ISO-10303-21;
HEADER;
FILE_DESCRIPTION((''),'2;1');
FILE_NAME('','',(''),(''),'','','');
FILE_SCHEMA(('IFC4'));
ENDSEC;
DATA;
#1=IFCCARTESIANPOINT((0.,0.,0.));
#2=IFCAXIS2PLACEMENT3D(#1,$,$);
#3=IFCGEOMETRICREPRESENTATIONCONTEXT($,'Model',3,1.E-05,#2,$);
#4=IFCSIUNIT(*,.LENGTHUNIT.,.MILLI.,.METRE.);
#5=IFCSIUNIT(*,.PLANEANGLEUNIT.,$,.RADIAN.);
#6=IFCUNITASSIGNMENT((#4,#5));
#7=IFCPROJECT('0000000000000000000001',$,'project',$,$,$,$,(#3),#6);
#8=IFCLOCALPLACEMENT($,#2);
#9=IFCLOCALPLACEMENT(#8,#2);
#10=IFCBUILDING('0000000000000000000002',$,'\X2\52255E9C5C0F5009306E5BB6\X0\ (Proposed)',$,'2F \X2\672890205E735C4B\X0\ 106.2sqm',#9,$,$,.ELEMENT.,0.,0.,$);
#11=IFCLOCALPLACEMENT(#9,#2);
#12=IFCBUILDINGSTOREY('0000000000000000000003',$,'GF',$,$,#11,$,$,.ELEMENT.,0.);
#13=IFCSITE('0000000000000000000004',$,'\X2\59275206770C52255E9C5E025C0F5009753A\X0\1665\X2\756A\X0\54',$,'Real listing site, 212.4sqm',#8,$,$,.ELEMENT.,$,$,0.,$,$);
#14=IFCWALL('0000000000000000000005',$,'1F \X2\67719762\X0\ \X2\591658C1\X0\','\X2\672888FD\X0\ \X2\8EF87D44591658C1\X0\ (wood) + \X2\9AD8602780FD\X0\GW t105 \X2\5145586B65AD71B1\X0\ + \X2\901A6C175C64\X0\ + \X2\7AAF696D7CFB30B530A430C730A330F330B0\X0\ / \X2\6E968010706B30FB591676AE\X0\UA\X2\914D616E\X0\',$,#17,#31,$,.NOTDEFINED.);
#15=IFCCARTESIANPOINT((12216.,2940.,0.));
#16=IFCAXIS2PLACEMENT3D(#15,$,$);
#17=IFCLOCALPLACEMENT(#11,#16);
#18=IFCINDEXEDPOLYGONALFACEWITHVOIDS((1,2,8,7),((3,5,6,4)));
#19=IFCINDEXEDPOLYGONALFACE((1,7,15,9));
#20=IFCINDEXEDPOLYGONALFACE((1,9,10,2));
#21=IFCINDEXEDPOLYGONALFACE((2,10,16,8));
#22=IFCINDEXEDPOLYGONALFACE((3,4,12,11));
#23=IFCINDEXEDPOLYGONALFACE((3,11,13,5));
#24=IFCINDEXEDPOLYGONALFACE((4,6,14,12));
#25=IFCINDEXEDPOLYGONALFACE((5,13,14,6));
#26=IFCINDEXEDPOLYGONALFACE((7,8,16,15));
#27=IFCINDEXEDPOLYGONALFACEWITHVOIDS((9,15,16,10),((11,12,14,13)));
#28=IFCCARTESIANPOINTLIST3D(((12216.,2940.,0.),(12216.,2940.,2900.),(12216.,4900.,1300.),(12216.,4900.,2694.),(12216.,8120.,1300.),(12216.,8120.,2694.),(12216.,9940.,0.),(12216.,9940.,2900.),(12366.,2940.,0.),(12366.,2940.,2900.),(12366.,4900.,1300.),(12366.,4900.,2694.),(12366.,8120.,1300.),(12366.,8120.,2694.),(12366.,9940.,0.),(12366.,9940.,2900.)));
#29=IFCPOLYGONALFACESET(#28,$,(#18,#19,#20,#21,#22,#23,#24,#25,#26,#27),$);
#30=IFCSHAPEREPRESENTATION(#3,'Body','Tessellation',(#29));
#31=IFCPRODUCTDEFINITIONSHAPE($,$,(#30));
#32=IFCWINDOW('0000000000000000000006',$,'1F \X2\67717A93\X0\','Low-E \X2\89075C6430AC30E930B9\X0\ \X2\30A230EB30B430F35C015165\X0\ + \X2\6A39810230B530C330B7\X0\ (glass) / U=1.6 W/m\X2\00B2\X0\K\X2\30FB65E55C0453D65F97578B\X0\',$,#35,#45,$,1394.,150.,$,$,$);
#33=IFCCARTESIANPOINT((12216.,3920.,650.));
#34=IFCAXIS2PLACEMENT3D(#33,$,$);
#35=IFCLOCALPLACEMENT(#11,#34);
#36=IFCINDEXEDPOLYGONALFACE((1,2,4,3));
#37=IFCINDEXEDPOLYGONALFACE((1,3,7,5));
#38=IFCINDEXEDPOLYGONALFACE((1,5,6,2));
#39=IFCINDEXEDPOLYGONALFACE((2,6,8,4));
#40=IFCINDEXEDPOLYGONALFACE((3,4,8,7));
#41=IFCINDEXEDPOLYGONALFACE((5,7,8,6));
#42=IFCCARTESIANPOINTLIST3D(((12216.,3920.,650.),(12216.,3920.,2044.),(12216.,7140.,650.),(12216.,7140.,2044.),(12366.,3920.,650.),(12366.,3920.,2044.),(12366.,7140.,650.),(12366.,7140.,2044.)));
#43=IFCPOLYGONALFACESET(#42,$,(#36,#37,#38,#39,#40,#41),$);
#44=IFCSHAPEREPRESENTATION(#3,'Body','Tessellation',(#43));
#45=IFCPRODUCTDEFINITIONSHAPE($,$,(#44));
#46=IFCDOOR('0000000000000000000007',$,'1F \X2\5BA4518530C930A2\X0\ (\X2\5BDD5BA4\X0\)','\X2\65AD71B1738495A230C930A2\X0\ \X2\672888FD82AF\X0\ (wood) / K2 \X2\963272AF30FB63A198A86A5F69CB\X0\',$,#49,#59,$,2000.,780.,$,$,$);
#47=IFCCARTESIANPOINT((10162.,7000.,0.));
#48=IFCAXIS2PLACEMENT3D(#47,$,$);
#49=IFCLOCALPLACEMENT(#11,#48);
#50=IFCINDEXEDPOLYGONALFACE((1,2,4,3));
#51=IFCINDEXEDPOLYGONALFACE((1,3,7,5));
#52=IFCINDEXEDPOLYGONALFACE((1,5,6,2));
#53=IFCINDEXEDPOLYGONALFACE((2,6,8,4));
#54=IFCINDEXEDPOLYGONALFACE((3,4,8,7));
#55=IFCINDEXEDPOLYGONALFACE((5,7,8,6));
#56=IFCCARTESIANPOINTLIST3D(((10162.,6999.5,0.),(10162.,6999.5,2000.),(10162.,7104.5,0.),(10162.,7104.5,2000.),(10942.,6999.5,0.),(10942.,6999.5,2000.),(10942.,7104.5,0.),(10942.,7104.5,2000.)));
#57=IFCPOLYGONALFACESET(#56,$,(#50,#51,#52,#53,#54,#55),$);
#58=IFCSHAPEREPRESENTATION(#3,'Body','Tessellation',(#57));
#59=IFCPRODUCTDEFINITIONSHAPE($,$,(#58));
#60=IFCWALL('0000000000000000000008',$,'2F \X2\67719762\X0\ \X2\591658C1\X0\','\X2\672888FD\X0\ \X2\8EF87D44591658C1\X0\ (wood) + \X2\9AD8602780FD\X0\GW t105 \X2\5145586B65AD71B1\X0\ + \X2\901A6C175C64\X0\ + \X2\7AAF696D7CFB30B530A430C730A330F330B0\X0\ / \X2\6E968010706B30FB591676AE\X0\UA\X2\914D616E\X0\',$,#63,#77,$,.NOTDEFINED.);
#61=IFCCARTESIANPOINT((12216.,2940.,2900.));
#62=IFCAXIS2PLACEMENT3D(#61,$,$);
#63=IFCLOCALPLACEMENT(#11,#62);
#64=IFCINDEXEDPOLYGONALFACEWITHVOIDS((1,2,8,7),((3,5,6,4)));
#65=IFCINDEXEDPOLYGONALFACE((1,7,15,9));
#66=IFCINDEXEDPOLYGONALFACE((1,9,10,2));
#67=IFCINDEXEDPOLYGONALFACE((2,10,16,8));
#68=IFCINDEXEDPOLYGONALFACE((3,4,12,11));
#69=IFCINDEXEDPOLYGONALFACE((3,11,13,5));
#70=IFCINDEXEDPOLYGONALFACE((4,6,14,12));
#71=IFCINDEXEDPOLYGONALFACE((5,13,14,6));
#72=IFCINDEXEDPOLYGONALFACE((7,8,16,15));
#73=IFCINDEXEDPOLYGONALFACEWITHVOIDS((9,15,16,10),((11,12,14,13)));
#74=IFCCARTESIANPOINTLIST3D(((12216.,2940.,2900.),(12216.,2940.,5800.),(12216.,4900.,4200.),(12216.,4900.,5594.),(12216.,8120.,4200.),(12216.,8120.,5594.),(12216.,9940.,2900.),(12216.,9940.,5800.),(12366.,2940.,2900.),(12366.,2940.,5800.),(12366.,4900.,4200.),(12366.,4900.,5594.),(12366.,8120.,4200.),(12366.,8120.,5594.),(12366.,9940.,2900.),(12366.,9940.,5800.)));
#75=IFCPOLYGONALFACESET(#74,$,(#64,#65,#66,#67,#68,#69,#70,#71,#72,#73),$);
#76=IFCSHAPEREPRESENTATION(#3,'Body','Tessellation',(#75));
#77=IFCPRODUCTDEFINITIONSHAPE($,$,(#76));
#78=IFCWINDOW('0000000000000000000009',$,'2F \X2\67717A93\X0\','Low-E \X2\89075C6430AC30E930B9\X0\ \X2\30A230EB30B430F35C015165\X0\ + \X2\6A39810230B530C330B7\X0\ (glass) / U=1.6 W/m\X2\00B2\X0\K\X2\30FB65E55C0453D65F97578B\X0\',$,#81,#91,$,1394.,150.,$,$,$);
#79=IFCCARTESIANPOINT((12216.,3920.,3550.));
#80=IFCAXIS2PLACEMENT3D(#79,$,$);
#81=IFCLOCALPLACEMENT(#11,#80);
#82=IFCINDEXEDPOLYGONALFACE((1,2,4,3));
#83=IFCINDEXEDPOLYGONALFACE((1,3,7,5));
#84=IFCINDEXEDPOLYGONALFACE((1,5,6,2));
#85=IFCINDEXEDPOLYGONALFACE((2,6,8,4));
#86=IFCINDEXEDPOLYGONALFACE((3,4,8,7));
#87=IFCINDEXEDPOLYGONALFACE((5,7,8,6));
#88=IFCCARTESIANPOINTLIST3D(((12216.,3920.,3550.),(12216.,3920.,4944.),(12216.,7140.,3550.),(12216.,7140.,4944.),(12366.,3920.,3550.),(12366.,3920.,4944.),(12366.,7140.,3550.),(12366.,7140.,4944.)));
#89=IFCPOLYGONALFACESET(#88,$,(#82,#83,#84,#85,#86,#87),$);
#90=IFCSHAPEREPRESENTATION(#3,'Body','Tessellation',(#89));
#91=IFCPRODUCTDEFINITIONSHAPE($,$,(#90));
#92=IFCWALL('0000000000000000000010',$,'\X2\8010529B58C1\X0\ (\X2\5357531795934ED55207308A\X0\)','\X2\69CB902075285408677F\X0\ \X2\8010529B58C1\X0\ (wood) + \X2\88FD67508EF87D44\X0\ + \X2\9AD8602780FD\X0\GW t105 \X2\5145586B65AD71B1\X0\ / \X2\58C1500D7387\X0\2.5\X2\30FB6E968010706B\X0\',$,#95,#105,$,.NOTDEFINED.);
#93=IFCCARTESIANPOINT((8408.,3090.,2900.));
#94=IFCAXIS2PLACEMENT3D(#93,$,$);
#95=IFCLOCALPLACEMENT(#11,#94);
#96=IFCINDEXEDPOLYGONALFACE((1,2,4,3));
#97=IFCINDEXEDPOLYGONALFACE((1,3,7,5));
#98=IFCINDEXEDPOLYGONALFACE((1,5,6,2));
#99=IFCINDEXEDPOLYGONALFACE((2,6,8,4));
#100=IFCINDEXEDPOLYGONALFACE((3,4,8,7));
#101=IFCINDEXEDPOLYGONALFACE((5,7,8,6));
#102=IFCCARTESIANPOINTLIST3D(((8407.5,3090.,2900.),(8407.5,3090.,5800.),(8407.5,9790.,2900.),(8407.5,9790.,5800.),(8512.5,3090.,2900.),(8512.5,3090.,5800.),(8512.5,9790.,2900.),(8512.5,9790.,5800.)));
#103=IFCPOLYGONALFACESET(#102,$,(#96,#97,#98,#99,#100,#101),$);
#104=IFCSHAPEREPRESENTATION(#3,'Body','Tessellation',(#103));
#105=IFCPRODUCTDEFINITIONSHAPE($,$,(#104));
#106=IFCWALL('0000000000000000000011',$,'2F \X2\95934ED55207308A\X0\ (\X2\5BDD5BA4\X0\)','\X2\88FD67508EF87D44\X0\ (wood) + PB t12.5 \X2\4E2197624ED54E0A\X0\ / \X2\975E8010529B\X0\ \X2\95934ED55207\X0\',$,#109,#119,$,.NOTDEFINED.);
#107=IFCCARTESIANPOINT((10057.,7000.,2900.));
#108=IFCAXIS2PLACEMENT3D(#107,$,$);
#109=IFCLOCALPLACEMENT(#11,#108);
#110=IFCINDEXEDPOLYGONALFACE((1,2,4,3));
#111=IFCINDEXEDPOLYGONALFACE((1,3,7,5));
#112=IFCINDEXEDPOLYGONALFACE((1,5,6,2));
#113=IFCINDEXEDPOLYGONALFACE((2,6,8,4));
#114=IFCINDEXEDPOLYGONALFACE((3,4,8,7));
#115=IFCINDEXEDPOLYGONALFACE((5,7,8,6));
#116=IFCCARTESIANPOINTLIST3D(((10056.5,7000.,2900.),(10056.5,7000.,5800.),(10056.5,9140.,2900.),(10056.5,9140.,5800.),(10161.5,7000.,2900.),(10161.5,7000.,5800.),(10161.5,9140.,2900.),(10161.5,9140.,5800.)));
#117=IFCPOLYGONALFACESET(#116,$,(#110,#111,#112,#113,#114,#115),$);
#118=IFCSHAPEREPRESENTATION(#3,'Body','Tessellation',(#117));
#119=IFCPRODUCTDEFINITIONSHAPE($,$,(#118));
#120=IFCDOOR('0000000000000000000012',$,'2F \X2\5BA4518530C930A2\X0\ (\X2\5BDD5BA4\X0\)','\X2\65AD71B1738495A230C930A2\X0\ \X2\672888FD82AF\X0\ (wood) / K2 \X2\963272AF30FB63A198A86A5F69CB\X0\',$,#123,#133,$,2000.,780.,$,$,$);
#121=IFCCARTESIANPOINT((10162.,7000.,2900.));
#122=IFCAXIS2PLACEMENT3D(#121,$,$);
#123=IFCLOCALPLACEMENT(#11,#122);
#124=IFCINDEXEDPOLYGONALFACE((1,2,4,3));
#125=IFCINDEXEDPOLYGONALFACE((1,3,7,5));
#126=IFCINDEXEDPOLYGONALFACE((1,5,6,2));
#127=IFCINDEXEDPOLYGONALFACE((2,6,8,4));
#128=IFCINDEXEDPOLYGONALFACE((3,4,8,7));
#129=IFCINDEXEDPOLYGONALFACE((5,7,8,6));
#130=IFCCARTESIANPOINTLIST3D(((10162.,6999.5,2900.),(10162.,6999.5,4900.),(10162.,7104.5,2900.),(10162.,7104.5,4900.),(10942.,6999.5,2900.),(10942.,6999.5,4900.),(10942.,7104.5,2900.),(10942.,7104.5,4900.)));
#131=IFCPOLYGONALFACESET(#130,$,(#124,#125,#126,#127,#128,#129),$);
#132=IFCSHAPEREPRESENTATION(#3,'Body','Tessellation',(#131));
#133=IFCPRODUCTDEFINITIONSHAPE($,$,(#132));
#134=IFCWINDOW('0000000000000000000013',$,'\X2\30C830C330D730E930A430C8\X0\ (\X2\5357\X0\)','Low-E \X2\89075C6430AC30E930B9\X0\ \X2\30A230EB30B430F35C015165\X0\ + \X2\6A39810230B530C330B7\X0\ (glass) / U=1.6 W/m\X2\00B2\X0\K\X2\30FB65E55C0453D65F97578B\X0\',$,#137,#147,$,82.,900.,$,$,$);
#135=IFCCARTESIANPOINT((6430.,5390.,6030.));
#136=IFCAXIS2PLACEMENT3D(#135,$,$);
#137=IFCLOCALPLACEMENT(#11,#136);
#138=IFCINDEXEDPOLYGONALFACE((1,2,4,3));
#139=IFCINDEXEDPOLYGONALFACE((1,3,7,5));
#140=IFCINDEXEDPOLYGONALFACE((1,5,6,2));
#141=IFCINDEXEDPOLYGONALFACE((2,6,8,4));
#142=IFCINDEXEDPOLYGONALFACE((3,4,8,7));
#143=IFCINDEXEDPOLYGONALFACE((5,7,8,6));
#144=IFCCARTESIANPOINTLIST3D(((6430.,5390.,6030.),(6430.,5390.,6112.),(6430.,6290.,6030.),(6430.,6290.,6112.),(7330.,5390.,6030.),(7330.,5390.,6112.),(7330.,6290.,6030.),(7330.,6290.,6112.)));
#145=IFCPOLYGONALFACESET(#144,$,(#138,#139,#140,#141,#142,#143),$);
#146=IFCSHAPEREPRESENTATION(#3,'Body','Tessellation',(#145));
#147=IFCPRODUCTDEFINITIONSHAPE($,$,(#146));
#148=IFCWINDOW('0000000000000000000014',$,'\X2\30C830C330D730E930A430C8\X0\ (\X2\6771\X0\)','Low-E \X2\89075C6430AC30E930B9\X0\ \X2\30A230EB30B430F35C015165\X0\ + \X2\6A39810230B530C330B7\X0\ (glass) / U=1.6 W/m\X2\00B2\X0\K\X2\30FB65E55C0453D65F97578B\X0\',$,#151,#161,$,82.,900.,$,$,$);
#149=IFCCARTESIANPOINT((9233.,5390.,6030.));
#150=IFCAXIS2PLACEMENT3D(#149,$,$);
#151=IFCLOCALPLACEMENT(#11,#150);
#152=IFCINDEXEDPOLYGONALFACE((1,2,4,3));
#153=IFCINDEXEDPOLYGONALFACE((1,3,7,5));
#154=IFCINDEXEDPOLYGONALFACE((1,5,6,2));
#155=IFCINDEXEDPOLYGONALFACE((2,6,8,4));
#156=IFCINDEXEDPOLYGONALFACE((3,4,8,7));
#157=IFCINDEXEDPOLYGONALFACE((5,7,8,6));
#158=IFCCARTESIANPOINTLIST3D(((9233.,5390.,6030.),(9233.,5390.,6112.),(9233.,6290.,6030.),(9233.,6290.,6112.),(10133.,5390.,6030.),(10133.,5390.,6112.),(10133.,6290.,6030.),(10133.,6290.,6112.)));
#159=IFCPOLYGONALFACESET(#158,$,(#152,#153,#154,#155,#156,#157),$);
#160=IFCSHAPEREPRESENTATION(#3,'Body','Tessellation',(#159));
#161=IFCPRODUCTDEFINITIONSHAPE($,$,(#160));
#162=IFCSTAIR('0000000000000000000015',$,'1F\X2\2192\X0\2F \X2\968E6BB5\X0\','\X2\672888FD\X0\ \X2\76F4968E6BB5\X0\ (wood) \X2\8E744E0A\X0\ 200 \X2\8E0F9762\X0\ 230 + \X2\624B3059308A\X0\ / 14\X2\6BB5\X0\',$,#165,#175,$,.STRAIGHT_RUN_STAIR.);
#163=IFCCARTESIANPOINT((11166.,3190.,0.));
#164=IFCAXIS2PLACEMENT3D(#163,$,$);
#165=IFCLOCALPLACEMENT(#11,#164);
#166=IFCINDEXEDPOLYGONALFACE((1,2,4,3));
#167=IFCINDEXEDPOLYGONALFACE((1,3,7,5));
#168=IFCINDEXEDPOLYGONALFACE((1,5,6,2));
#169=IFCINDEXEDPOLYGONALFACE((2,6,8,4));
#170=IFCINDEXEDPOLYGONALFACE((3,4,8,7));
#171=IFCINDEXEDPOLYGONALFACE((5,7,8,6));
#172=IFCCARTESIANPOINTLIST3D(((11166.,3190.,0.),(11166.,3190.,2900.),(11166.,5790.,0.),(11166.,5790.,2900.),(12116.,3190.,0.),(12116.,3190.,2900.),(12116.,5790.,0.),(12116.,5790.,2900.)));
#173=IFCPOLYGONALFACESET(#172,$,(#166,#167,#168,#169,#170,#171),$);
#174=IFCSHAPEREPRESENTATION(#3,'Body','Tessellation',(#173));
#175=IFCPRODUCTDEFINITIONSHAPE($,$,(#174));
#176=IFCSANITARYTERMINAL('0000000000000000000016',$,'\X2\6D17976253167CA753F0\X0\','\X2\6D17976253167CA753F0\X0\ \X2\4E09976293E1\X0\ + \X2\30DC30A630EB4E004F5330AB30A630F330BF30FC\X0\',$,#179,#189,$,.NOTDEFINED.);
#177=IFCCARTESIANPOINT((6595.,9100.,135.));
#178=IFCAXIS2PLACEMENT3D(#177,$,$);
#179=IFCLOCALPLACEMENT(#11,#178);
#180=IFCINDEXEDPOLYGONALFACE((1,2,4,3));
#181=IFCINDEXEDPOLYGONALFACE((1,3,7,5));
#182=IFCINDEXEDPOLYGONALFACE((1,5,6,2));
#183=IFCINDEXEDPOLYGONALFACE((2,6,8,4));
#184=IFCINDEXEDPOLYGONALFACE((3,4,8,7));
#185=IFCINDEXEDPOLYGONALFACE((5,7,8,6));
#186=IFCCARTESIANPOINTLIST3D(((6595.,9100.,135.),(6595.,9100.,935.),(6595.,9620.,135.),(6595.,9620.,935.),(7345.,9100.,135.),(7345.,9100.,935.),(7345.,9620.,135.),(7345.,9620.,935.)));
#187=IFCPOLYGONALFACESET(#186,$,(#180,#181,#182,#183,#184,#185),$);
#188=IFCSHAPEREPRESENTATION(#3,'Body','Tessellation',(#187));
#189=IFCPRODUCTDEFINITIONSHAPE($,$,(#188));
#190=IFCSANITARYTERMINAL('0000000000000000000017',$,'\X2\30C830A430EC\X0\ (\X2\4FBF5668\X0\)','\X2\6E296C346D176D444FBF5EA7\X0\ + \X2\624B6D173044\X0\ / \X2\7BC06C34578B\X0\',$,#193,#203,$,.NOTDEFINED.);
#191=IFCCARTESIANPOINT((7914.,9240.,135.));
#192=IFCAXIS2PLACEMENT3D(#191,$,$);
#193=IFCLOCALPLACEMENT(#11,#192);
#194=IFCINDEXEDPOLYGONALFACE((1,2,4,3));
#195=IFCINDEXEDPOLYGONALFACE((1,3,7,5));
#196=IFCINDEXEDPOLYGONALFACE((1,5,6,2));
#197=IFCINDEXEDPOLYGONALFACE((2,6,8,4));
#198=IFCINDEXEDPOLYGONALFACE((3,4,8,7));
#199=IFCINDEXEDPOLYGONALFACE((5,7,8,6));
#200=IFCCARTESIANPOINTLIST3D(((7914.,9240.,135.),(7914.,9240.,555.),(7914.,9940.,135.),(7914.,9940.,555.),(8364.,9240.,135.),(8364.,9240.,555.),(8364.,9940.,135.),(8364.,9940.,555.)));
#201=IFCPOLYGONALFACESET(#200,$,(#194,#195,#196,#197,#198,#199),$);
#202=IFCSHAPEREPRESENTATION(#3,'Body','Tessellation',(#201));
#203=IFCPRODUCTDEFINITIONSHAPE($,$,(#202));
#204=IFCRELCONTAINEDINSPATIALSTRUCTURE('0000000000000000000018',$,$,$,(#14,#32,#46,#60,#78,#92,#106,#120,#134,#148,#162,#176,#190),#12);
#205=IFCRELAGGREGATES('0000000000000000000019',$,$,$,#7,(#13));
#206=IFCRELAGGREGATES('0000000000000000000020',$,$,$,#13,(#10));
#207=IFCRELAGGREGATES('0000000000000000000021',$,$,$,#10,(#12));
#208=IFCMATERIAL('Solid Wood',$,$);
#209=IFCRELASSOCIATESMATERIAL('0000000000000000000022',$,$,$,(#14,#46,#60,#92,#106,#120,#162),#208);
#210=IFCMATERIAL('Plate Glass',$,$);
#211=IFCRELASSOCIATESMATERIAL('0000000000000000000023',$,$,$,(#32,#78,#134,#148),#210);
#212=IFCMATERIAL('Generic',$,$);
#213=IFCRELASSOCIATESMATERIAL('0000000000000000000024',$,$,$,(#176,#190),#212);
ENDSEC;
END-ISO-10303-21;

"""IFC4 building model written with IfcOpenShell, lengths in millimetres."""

from ifc_helpers import new_model, si_unit, frame, frame_2d, origin, place, context, project, spatial, rectangle, extrude, material, element, fill, save


model = new_model("IFC4")

# Units and contexts
model_context = context("Model", 3, precision=1e-05, world=origin())
ifc_project = project(units=[si_unit("LENGTHUNIT", "METRE", prefix="MILLI"), si_unit("PLANEANGLEUNIT", "RADIAN")], contexts=[model_context])

# Site, building, storey
site_placement = place(None, origin())
site = spatial("IfcSite", under=ifc_project, at=site_placement, Name="大分県別府市小倉町1665番54", ObjectType="Real listing site, 212.4sqm", CompositionType="ELEMENT", RefElevation=0.0)
building_placement = place(site_placement, origin())
building = spatial("IfcBuilding", under=site, at=building_placement, Name="別府小倉の家 (Proposed)", ObjectType="2F 木造平屋 106.2sqm", CompositionType="ELEMENT", ElevationOfRefHeight=0.0, ElevationOfTerrain=0.0)
storey_placement = place(building_placement, origin())
storey = spatial("IfcBuildingStorey", under=building, at=storey_placement, Name="GF", CompositionType="ELEMENT", Elevation=0.0)

# Wall, opening, window
ifc_material_1 = material(Name="Solid Wood")
wall_1_placement = place(storey_placement, frame((12216.0, 2940.0, 0.0)))
wall_1 = element("IfcWall", 1, at=wall_1_placement, inside=storey, material=ifc_material_1, Name="1F 東面 外壁", Description="木製 軸組外壁 (wood) + 高性能GW t105 充填断熱 + 通気層 + 窯業系サイディング / 準耐火・外皮UA配慮", PredefinedType="NOTDEFINED", context=model_context, shape_type="SweptSolid", body=[
    extrude(rectangle(XDim=150.0, YDim=7000.0, at=frame_2d((75.0, 3500.0))), frame((12216.0, 2940.0, 0.0)), (0.0, 0.0, 1.0), 2900.0),
])
opening_1_placement = place(storey_placement, frame((12216.0, 3920.0, 650.0)))
opening_1 = element("IfcOpeningElement", 2, at=opening_1_placement, cuts=wall_1, PredefinedType="NOTDEFINED", context=model_context, shape_type="SweptSolid", body=[
    extrude(rectangle(XDim=150.0, YDim=3220.0, at=frame_2d((75.0, 1610.0))), frame((12216.0, 3920.0, 650.0)), (0.0, 0.0, 1.0), 1394.0),
])
ifc_material_2 = material(Name="Plate Glass")
window_1_placement = place(storey_placement, frame((12216.0, 3920.0, 650.0)))
window_1 = element("IfcWindow", 3, at=window_1_placement, inside=storey, material=ifc_material_2, Name="1F 東窓", Description="Low-E 複層ガラス アルゴン封入 + 樹脂サッシ (glass) / U=1.6 W/m²K・日射取得型", OverallHeight=1394.0, OverallWidth=150.0, context=model_context, shape_type="SweptSolid", body=[
    extrude(rectangle(XDim=150.0, YDim=3220.0, at=frame_2d((75.0, 1610.0))), frame((12216.0, 3920.0, 650.0)), (0.0, 0.0, 1.0), 1394.0),
])
fill(opening_1, window_1)

# Door
door_1_placement = place(storey_placement, frame((10162.0, 7000.0, 0.0)))
element("IfcDoor", 4, at=door_1_placement, inside=storey, material=ifc_material_1, Name="1F 室内ドア (寝室)", Description="断熱玄関ドア 木製芯 (wood) / K2 防犯・採風機構", OverallHeight=2000.0, OverallWidth=780.0, context=model_context, shape_type="SweptSolid", body=[
    extrude(rectangle(XDim=780.0, YDim=105.0, at=frame_2d((390.0, 52.0))), frame((10162.0, 7000.0, 0.0)), (0.0, 0.0, 1.0), 2000.0),
])

# Wall, opening, window
wall_2_placement = place(storey_placement, frame((12216.0, 2940.0, 2900.0)))
wall_2 = element("IfcWall", 5, at=wall_2_placement, inside=storey, material=ifc_material_1, Name="2F 東面 外壁", Description="木製 軸組外壁 (wood) + 高性能GW t105 充填断熱 + 通気層 + 窯業系サイディング / 準耐火・外皮UA配慮", PredefinedType="NOTDEFINED", context=model_context, shape_type="SweptSolid", body=[
    extrude(rectangle(XDim=150.0, YDim=7000.0, at=frame_2d((75.0, 3500.0))), frame((12216.0, 2940.0, 2900.0)), (0.0, 0.0, 1.0), 2900.0),
])
opening_2_placement = place(storey_placement, frame((12216.0, 3920.0, 3550.0)))
opening_2 = element("IfcOpeningElement", 6, at=opening_2_placement, cuts=wall_2, PredefinedType="NOTDEFINED", context=model_context, shape_type="SweptSolid", body=[
    extrude(rectangle(XDim=150.0, YDim=3220.0, at=frame_2d((75.0, 1610.0))), frame((12216.0, 3920.0, 3550.0)), (0.0, 0.0, 1.0), 1394.0),
])
window_2_placement = place(storey_placement, frame((12216.0, 3920.0, 3550.0)))
window_2 = element("IfcWindow", 7, at=window_2_placement, inside=storey, material=ifc_material_2, Name="2F 東窓", Description="Low-E 複層ガラス アルゴン封入 + 樹脂サッシ (glass) / U=1.6 W/m²K・日射取得型", OverallHeight=1394.0, OverallWidth=150.0, context=model_context, shape_type="SweptSolid", body=[
    extrude(rectangle(XDim=150.0, YDim=3220.0, at=frame_2d((75.0, 1610.0))), frame((12216.0, 3920.0, 3550.0)), (0.0, 0.0, 1.0), 1394.0),
])
fill(opening_2, window_2)

# Walls
wall_3_placement = place(storey_placement, frame((8408.0, 3090.0, 2900.0)))
element("IfcWall", 8, at=wall_3_placement, inside=storey, material=ifc_material_1, Name="耐力壁 (南北間仕切り)", Description="構造用合板 耐力壁 (wood) + 製材軸組 + 高性能GW t105 充填断熱 / 壁倍率2.5・準耐火", PredefinedType="NOTDEFINED", context=model_context, shape_type="SweptSolid", body=[
    extrude(rectangle(XDim=105.0, YDim=6700.0, at=frame_2d((52.0, 3350.0))), frame((8408.0, 3090.0, 2900.0)), (0.0, 0.0, 1.0), 2900.0),
])
wall_4_placement = place(storey_placement, frame((10057.0, 7000.0, 2900.0)))
element("IfcWall", 9, at=wall_4_placement, inside=storey, material=ifc_material_1, Name="2F 間仕切り (寝室)", Description="製材軸組 (wood) + PB t12.5 両面仕上 / 非耐力 間仕切", PredefinedType="NOTDEFINED", context=model_context, shape_type="SweptSolid", body=[
    extrude(rectangle(XDim=105.0, YDim=2140.0, at=frame_2d((52.0, 1070.0))), frame((10057.0, 7000.0, 2900.0)), (0.0, 0.0, 1.0), 2900.0),
])

# Door
door_2_placement = place(storey_placement, frame((10162.0, 7000.0, 2900.0)))
element("IfcDoor", 10, at=door_2_placement, inside=storey, material=ifc_material_1, Name="2F 室内ドア (寝室)", Description="断熱玄関ドア 木製芯 (wood) / K2 防犯・採風機構", OverallHeight=2000.0, OverallWidth=780.0, context=model_context, shape_type="SweptSolid", body=[
    extrude(rectangle(XDim=780.0, YDim=105.0, at=frame_2d((390.0, 52.0))), frame((10162.0, 7000.0, 2900.0)), (0.0, 0.0, 1.0), 2000.0),
])

# Windows
window_3_placement = place(storey_placement, frame((6430.0, 5390.0, 6030.0)))
element("IfcWindow", 11, at=window_3_placement, inside=storey, material=ifc_material_2, Name="トップライト (南)", Description="Low-E 複層ガラス アルゴン封入 + 樹脂サッシ (glass) / U=1.6 W/m²K・日射取得型", OverallHeight=82.0, OverallWidth=900.0, context=model_context, shape_type="SweptSolid", body=[
    extrude(rectangle(XDim=900.0, YDim=900.0, at=frame_2d((450.0, 450.0))), frame((6430.0, 5390.0, 6030.0)), (0.0, 0.0, 1.0), 82.0),
])
window_4_placement = place(storey_placement, frame((9233.0, 5390.0, 6030.0)))
element("IfcWindow", 12, at=window_4_placement, inside=storey, material=ifc_material_2, Name="トップライト (東)", Description="Low-E 複層ガラス アルゴン封入 + 樹脂サッシ (glass) / U=1.6 W/m²K・日射取得型", OverallHeight=82.0, OverallWidth=900.0, context=model_context, shape_type="SweptSolid", body=[
    extrude(rectangle(XDim=900.0, YDim=900.0, at=frame_2d((450.0, 450.0))), frame((9233.0, 5390.0, 6030.0)), (0.0, 0.0, 1.0), 82.0),
])

# Stair
stair_placement = place(storey_placement, frame((11166.0, 3190.0, 0.0)))
element("IfcStair", 13, at=stair_placement, inside=storey, material=ifc_material_1, Name="1F→2F 階段", Description="木製 直階段 (wood) 蹴上 200 踏面 230 + 手すり / 14段", PredefinedType="STRAIGHT_RUN_STAIR", context=model_context, shape_type="SweptSolid", body=[
    extrude(rectangle(XDim=950.0, YDim=2600.0, at=frame_2d((475.0, 1300.0))), frame((11166.0, 3190.0, 0.0)), (0.0, 0.0, 1.0), 2900.0),
])

# Sanitary terminals
ifc_material_3 = material(Name="Generic")
sanitary_terminal_1_placement = place(storey_placement, frame((6595.0, 9100.0, 135.0)))
element("IfcSanitaryTerminal", 14, at=sanitary_terminal_1_placement, inside=storey, material=ifc_material_3, Name="洗面化粧台", Description="洗面化粧台 三面鏡 + ボウル一体カウンター", PredefinedType="NOTDEFINED", context=model_context, shape_type="SweptSolid", body=[
    extrude(rectangle(XDim=750.0, YDim=520.0, at=frame_2d((375.0, 260.0))), frame((6595.0, 9100.0, 135.0)), (0.0, 0.0, 1.0), 800.0),
])
sanitary_terminal_2_placement = place(storey_placement, frame((7914.0, 9240.0, 135.0)))
element("IfcSanitaryTerminal", 15, at=sanitary_terminal_2_placement, inside=storey, material=ifc_material_3, Name="トイレ (便器)", Description="温水洗浄便座 + 手洗い / 節水型", PredefinedType="NOTDEFINED", context=model_context, shape_type="SweptSolid", body=[
    extrude(rectangle(XDim=450.0, YDim=700.0, at=frame_2d((225.0, 350.0))), frame((7914.0, 9240.0, 135.0)), (0.0, 0.0, 1.0), 420.0),
])

save(model, "model.ifc")
